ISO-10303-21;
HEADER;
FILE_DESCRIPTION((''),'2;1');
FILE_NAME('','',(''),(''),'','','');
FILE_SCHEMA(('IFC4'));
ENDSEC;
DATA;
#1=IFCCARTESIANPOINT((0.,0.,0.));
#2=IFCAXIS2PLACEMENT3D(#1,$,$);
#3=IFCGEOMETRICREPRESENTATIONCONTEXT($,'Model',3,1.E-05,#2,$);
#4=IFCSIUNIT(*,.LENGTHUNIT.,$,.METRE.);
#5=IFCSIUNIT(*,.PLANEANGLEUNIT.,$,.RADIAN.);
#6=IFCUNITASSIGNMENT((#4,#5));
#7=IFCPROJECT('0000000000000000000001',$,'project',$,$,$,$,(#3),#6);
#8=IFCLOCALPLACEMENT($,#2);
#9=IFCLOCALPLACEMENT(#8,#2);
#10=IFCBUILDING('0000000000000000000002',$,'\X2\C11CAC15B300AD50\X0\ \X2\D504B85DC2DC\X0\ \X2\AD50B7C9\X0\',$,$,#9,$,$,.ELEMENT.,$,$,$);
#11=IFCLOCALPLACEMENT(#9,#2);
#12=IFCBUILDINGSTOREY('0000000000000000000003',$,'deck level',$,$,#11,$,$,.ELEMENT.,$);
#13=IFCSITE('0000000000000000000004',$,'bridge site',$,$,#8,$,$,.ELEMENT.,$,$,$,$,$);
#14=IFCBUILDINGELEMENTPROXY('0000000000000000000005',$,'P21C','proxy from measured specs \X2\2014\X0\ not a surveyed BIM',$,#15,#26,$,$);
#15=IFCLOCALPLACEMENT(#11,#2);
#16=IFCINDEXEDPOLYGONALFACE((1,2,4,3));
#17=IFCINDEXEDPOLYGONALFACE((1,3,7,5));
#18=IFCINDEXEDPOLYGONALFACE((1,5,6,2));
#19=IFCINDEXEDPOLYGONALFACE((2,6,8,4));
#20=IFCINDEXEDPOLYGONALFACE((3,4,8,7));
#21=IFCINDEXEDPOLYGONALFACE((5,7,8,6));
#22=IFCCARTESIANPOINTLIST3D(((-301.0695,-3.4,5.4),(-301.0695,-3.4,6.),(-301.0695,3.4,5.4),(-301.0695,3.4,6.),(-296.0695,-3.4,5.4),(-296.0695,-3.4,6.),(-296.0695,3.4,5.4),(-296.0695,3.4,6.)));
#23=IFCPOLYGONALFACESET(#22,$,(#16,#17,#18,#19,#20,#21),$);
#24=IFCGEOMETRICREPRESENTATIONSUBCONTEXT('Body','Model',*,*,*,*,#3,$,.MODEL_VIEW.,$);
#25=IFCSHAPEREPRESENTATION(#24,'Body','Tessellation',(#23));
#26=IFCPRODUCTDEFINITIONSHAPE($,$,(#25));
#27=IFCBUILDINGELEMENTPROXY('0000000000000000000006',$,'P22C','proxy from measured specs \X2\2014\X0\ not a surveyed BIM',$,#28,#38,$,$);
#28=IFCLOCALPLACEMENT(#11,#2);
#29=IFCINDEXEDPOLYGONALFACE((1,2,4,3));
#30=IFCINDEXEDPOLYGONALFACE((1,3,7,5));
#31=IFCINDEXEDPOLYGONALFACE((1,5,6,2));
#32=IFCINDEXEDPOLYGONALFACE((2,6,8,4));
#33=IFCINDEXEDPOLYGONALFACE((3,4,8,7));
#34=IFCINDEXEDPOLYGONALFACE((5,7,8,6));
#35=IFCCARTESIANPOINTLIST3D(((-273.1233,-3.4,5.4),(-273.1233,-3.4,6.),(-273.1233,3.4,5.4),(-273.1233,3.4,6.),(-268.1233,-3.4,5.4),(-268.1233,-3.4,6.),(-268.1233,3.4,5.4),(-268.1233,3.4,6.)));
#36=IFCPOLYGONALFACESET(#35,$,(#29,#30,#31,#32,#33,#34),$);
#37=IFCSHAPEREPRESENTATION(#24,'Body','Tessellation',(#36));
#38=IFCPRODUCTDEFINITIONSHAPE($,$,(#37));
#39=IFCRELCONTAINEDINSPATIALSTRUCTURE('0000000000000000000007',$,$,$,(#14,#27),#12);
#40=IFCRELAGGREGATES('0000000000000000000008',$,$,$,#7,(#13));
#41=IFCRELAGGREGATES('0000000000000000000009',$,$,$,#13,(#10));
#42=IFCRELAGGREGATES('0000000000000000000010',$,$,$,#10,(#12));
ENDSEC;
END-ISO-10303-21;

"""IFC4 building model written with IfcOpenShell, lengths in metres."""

from ifc_helpers import new_model, si_unit, frame, origin, origin_2d, place, context, subcontext, project, spatial, rectangle, extrude, element, save


model = new_model("IFC4")

# Units and contexts
model_context = context("Model", 3, precision=1e-05, world=origin())
body_context = subcontext(model_context, "Body", "Model", "MODEL_VIEW")
ifc_project = project(units=[si_unit("LENGTHUNIT", "METRE"), si_unit("PLANEANGLEUNIT", "RADIAN")], contexts=[model_context])

# Site, building, storey
site_placement = place(None, origin())
site = spatial("IfcSite", under=ifc_project, at=site_placement, Name="bridge site", CompositionType="ELEMENT")
building_placement = place(site_placement, origin())
building = spatial("IfcBuilding", under=site, at=building_placement, Name="서강대교 프록시 교량", CompositionType="ELEMENT")
storey_placement = place(building_placement, origin())
storey = spatial("IfcBuildingStorey", under=building, at=storey_placement, Name="deck level", CompositionType="ELEMENT")

# Building element proxies
for number, where, name in (
    (1, (-298.5695, 0.0, 5.4), "P21C"),
    (2, (-270.6233, 0.0, 5.4), "P22C"),
):
    element("IfcBuildingElementProxy", number, at=place(storey_placement, frame(where)), inside=storey, Name=name, Description="proxy from measured specs — not a surveyed BIM", context=body_context, shape_type="SweptSolid", body=[
        extrude(rectangle(XDim=5.0, YDim=6.8, at=origin_2d()), origin(), (0.0, 0.0, 1.0), 0.6),
    ])

save(model, "model.ifc")
